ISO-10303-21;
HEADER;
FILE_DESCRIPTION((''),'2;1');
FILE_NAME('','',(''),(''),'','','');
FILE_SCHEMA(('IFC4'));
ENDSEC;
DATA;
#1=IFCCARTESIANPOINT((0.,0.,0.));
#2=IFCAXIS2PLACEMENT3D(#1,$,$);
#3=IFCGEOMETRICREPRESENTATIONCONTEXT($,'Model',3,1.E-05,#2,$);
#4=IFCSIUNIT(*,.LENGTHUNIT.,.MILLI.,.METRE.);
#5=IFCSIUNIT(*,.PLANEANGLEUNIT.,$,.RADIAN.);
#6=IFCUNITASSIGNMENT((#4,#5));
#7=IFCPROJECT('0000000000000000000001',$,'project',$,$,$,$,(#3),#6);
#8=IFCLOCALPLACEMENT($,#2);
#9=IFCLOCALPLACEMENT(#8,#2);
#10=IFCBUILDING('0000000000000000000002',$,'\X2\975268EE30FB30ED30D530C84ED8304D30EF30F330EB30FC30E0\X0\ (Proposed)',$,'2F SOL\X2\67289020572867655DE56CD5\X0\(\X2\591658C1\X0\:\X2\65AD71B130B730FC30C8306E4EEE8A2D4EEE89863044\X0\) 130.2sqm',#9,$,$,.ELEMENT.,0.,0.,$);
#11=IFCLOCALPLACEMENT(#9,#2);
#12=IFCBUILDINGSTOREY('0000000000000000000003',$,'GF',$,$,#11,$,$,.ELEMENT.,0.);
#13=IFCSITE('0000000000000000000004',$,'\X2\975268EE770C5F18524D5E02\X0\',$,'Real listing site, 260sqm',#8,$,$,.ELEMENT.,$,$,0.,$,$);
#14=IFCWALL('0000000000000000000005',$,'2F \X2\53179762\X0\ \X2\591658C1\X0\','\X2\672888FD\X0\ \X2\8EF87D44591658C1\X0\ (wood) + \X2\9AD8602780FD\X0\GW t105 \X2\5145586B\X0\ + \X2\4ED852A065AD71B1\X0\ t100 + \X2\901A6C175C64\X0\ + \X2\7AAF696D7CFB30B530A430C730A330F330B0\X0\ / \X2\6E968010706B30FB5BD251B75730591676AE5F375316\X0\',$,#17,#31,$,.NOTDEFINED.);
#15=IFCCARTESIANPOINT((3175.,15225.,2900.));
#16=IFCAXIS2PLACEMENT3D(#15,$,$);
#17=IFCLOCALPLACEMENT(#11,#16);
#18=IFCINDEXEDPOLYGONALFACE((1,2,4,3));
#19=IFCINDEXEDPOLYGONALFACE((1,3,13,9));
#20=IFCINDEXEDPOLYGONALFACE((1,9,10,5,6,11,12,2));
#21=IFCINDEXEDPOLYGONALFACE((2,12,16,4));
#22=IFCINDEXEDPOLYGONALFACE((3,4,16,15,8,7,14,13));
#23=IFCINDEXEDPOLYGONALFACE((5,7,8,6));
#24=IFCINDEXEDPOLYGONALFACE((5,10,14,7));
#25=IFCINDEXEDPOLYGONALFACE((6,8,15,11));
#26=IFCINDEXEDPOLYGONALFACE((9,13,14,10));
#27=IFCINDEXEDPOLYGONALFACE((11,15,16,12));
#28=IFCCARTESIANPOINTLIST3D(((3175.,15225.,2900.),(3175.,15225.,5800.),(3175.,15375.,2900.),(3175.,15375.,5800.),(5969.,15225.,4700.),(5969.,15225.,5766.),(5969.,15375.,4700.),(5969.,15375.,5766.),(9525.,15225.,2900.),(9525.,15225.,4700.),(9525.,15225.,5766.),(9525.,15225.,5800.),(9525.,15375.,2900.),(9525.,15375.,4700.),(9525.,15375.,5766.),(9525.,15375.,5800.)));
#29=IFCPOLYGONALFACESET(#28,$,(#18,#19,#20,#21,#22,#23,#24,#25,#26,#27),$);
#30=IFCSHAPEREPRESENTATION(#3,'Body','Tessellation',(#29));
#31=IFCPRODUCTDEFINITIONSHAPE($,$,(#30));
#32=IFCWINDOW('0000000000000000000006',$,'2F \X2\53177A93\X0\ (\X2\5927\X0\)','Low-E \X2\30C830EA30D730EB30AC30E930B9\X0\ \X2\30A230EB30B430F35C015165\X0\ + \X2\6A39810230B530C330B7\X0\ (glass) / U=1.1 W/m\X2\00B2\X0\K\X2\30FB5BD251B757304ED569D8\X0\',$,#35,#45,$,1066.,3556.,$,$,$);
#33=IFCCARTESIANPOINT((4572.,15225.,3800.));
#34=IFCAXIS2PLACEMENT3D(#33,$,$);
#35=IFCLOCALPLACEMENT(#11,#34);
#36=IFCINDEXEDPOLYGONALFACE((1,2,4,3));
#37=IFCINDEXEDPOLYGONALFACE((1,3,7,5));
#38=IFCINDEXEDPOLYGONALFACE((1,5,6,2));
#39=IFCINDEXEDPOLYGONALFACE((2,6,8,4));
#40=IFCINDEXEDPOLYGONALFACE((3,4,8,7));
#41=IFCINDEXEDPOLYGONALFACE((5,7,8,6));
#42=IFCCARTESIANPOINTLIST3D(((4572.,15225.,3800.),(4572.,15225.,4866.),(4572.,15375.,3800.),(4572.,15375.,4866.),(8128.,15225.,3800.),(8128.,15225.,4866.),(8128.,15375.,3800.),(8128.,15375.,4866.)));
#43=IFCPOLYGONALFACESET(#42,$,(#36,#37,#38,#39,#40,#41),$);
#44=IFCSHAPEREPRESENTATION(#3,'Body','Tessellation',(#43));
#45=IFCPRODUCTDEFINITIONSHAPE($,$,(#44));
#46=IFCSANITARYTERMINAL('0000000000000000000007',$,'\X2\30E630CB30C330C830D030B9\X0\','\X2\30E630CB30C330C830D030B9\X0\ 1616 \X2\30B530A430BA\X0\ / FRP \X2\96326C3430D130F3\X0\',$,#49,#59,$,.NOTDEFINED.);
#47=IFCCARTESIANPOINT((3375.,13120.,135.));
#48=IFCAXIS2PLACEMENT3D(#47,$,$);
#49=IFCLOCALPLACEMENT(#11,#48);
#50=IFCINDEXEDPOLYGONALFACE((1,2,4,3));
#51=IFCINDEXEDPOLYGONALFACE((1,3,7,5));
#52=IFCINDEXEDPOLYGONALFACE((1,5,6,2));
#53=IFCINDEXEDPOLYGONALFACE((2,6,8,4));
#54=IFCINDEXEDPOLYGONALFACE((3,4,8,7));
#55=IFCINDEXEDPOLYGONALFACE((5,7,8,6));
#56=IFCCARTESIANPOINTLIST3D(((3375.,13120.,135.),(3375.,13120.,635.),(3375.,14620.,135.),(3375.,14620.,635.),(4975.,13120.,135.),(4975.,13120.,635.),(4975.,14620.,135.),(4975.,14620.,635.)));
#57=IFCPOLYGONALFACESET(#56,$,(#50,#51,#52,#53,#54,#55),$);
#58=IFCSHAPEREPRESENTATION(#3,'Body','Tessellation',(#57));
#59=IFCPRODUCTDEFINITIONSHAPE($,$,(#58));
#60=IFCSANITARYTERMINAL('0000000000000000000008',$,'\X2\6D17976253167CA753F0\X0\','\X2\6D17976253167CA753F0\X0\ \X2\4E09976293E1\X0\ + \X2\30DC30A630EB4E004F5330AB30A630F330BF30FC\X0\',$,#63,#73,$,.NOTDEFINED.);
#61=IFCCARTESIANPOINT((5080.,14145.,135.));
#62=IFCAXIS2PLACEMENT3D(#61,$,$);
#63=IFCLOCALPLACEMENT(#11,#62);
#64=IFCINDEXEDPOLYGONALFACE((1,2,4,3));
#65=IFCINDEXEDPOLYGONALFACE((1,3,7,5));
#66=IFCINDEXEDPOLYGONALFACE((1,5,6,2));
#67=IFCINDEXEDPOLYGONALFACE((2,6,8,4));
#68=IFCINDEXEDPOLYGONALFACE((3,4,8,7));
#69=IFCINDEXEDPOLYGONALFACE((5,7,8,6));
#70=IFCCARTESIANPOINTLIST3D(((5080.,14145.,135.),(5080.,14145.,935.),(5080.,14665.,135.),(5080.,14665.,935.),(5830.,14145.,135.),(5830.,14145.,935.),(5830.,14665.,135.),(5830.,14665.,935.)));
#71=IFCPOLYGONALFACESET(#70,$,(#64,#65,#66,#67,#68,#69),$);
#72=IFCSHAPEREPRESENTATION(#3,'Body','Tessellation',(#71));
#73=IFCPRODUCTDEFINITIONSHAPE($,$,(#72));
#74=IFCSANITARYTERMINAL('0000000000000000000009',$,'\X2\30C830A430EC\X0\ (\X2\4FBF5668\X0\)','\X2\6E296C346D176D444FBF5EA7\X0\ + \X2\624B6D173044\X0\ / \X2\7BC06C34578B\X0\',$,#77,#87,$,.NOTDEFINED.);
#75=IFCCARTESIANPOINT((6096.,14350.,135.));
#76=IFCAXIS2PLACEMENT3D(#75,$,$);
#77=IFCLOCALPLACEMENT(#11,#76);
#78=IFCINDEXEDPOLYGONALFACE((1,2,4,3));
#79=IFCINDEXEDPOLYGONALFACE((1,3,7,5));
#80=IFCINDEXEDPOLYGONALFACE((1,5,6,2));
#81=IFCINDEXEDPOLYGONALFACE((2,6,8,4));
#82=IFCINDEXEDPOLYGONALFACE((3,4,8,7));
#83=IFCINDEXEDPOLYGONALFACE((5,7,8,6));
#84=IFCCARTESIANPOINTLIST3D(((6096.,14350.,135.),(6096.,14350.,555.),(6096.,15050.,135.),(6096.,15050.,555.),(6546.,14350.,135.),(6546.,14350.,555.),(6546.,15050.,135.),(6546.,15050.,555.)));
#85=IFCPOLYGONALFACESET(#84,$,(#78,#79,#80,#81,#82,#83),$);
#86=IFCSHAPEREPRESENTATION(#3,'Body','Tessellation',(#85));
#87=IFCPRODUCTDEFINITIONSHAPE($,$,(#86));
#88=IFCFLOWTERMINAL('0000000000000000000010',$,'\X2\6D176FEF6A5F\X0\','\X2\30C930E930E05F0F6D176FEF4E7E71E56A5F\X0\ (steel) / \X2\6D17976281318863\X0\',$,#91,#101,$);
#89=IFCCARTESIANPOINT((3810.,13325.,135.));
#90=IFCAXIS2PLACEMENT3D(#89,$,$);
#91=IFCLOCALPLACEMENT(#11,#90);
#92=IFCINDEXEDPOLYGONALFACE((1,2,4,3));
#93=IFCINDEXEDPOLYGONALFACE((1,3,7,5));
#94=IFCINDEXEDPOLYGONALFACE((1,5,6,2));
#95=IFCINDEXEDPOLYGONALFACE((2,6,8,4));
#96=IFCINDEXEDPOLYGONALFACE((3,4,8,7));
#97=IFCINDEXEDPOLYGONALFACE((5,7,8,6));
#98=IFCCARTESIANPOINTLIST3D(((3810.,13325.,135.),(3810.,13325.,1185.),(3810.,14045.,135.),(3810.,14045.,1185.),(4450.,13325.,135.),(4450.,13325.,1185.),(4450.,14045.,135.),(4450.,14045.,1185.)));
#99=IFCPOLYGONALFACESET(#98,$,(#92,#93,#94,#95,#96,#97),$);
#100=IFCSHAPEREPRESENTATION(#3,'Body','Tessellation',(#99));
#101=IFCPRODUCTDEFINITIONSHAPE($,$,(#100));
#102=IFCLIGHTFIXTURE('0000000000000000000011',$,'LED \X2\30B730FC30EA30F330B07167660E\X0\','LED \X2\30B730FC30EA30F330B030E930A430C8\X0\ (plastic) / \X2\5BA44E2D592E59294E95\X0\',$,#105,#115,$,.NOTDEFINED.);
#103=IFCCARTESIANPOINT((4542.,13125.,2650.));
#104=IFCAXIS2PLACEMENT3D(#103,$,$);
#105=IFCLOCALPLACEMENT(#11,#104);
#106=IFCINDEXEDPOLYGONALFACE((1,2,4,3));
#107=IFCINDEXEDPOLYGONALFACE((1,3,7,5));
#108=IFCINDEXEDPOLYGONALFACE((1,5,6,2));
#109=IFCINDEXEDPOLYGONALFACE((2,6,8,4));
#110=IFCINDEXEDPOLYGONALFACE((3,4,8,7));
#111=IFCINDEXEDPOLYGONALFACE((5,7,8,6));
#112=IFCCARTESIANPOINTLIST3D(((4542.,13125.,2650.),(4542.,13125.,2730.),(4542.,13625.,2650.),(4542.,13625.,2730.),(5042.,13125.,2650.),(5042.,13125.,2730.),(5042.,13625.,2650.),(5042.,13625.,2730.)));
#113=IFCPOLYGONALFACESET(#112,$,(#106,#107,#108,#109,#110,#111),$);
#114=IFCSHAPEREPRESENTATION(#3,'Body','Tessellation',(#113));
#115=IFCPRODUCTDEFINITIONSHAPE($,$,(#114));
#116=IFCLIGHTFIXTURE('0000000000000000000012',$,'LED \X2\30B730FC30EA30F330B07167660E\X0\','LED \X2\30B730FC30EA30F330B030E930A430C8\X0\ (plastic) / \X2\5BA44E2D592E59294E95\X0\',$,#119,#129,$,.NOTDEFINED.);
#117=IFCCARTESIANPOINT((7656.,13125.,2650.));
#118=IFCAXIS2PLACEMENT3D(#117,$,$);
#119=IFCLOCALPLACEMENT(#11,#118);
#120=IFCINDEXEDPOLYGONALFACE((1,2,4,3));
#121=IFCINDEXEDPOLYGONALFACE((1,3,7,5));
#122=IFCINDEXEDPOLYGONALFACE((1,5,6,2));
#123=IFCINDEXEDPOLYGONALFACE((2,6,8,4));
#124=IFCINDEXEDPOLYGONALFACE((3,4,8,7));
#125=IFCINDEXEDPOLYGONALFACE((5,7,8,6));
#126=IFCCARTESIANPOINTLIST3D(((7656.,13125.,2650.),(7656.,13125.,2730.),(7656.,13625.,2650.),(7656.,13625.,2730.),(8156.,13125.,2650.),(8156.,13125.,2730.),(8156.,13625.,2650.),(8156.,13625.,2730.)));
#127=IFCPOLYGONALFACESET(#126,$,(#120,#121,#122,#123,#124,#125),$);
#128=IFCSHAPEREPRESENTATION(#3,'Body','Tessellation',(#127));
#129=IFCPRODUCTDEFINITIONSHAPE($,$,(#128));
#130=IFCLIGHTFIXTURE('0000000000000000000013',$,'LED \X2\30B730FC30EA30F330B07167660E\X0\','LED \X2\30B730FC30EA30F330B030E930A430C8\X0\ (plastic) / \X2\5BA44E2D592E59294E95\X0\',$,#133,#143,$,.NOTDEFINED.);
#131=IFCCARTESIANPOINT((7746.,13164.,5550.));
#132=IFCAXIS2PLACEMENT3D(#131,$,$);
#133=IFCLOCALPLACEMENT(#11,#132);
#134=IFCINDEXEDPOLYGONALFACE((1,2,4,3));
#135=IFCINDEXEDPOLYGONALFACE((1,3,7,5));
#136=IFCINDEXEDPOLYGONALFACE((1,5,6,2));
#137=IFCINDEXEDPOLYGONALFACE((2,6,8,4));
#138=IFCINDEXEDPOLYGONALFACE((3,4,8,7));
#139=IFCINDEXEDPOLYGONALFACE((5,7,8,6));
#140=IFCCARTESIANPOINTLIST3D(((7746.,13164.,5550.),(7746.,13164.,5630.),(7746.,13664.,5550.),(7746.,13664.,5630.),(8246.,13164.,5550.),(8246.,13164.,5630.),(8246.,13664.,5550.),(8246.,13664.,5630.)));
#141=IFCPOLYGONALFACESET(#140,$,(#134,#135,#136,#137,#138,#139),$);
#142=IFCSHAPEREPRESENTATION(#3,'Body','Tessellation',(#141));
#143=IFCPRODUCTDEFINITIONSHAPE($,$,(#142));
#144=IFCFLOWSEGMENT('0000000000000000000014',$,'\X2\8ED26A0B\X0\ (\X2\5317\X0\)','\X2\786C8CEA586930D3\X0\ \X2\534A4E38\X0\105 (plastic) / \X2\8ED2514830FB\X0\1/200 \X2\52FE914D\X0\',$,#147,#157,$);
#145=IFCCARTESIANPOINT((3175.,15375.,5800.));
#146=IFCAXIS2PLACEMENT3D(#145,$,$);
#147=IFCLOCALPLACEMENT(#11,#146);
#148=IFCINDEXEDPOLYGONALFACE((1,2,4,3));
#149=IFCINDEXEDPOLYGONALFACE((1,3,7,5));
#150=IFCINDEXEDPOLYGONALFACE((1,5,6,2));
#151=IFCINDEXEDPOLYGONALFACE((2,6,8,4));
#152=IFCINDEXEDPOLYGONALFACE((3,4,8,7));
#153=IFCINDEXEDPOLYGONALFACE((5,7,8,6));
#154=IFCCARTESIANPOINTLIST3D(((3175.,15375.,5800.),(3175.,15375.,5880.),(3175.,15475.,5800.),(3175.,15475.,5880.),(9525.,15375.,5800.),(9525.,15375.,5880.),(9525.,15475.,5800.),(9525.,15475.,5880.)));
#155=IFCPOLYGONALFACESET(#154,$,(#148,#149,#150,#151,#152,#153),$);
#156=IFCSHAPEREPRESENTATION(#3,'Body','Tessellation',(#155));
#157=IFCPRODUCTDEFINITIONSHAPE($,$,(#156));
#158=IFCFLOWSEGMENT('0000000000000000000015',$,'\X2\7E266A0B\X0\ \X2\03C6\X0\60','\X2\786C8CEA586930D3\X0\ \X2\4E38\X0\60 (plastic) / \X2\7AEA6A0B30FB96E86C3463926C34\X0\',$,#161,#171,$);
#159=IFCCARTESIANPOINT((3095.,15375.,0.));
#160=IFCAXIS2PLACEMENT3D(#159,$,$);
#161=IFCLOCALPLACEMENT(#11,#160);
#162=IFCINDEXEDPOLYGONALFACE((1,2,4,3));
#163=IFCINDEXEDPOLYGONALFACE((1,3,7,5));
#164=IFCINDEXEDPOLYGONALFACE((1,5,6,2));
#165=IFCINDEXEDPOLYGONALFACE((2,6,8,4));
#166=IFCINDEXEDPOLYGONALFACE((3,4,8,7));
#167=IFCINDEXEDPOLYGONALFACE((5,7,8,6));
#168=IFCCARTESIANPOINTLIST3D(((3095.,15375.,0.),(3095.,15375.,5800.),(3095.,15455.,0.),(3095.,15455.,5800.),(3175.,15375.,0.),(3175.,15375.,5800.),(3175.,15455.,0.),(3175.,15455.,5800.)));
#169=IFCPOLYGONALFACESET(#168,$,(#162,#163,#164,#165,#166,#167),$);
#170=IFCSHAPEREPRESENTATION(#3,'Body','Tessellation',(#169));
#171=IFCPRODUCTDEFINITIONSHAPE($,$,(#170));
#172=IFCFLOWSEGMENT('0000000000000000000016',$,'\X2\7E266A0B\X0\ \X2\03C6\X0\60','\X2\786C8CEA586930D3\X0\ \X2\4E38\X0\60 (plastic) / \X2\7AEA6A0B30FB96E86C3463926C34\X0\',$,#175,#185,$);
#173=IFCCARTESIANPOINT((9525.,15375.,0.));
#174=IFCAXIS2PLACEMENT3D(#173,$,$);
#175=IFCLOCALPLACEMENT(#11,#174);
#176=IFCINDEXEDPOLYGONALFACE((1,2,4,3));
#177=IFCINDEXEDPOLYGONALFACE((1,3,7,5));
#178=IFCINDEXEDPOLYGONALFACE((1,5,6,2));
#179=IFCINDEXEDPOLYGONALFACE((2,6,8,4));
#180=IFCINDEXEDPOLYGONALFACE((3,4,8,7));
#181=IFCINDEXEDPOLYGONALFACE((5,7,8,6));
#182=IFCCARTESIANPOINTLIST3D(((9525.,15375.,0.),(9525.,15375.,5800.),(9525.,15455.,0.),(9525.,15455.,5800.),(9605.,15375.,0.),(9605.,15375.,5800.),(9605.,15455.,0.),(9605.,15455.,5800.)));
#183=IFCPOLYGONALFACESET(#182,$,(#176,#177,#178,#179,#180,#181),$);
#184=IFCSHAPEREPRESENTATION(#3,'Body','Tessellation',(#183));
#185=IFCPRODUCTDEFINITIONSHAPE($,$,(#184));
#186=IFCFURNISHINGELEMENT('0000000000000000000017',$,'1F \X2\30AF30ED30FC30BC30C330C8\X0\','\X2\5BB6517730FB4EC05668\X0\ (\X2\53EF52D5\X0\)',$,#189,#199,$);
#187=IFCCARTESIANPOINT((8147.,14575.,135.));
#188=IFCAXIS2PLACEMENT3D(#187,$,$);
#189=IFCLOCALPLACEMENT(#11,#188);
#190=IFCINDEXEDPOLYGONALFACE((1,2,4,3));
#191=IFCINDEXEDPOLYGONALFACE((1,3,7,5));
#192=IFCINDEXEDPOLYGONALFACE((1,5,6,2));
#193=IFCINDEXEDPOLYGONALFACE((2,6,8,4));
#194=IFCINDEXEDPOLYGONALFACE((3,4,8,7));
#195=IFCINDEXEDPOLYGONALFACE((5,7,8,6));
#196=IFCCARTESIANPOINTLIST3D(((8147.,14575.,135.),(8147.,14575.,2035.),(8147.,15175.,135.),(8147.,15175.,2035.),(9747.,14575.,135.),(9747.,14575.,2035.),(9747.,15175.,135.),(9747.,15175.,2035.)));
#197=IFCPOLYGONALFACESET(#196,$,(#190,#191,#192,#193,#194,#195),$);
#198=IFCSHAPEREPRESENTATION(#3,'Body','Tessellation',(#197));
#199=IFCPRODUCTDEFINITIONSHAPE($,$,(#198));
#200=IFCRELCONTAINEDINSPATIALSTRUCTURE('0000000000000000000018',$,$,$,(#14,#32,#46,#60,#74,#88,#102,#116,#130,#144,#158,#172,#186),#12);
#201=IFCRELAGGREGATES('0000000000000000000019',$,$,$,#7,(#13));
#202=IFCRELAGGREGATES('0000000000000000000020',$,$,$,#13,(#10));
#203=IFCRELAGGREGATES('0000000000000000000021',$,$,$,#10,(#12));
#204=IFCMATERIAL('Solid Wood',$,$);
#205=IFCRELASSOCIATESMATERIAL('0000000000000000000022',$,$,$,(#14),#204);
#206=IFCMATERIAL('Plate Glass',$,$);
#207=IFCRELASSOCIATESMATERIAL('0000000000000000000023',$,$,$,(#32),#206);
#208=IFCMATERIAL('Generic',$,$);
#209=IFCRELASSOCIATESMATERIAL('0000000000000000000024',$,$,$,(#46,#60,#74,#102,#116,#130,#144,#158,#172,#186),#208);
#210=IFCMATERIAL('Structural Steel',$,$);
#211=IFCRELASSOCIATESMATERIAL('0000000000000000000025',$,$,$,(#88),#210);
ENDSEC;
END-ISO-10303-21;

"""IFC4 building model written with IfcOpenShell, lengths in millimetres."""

from ifc_helpers import new_model, si_unit, frame, frame_2d, origin, place, context, project, spatial, rectangle, extrude, material, element, fill, save


model = new_model("IFC4")

# Units and contexts
model_context = context("Model", 3, precision=1e-05, world=origin())
ifc_project = project(units=[si_unit("LENGTHUNIT", "METRE", prefix="MILLI"), si_unit("PLANEANGLEUNIT", "RADIAN")], contexts=[model_context])

# Site, building, storey
site_placement = place(None, origin())
site = spatial("IfcSite", under=ifc_project, at=site_placement, Name="青森県弘前市", ObjectType="Real listing site, 260sqm", CompositionType="ELEMENT", RefElevation=0.0)
building_placement = place(site_placement, origin())
building = spatial("IfcBuilding", under=site, at=building_placement, Name="青森・ロフト付きワンルーム (Proposed)", ObjectType="2F SOL木造在来工法(外壁:断熱シートの仮設仮覆い) 130.2sqm", CompositionType="ELEMENT", ElevationOfRefHeight=0.0, ElevationOfTerrain=0.0)
storey_placement = place(building_placement, origin())
storey = spatial("IfcBuildingStorey", under=building, at=storey_placement, Name="GF", CompositionType="ELEMENT", Elevation=0.0)

# Shared definitions
ifc_material_1 = material(Name="Solid Wood")

# Shared definitions
ifc_material_2 = material(Name="Plate Glass")

# Wall, opening, window
wall_1_placement = place(storey_placement, frame((3175.0, 15225.0, 2900.0)))
wall_1 = element("IfcWall", 1, at=wall_1_placement, inside=storey, material=ifc_material_1, Name="2F 北面 外壁", Description="木製 軸組外壁 (wood) + 高性能GW t105 充填 + 付加断熱 t100 + 通気層 + 窯業系サイディング / 準耐火・寒冷地外皮強化", PredefinedType="NOTDEFINED", context=model_context, shape_type="SweptSolid", body=[
    extrude(rectangle(XDim=6350.0, YDim=150.0, at=frame_2d((3175.0, 75.0))), frame((3175.0, 15225.0, 2900.0)), (0.0, 0.0, 1.0), 2900.0),
])
opening_1_placement = place(storey_placement, frame((4572.0, 15225.0, 3800.0)))
opening_1 = element("IfcOpeningElement", 2, at=opening_1_placement, cuts=wall_1, PredefinedType="NOTDEFINED", context=model_context, shape_type="SweptSolid", body=[
    extrude(rectangle(XDim=3556.0, YDim=150.0, at=frame_2d((1778.0, 75.0))), frame((4572.0, 15225.0, 3800.0)), (0.0, 0.0, 1.0), 1066.0),
])
window_1_placement = place(storey_placement, frame((4572.0, 15225.0, 3800.0)))
window_1 = element("IfcWindow", 3, at=window_1_placement, inside=storey, material=ifc_material_2, Name="2F 北窓 (大)", Description="Low-E トリプルガラス アルゴン封入 + 樹脂サッシ (glass) / U=1.1 W/m²K・寒冷地仕様", OverallHeight=1066.0, OverallWidth=3556.0, context=model_context, shape_type="SweptSolid", body=[
    extrude(rectangle(XDim=3556.0, YDim=150.0, at=frame_2d((1778.0, 75.0))), frame((4572.0, 15225.0, 3800.0)), (0.0, 0.0, 1.0), 1066.0),
])
fill(opening_1, window_1)

# Sanitary terminals
ifc_material_3 = material(Name="Generic")
sanitary_terminal_1_placement = place(storey_placement, frame((3375.0, 13120.0, 135.0)))
element("IfcSanitaryTerminal", 4, at=sanitary_terminal_1_placement, inside=storey, material=ifc_material_3, Name="ユニットバス", Description="ユニットバス 1616 サイズ / FRP 防水パン", PredefinedType="NOTDEFINED", context=model_context, shape_type="SweptSolid", body=[
    extrude(rectangle(XDim=1600.0, YDim=1500.0, at=frame_2d((800.0, 750.0))), frame((3375.0, 13120.0, 135.0)), (0.0, 0.0, 1.0), 500.0),
])
sanitary_terminal_2_placement = place(storey_placement, frame((5080.0, 14145.0, 135.0)))
element("IfcSanitaryTerminal", 5, at=sanitary_terminal_2_placement, inside=storey, material=ifc_material_3, Name="洗面化粧台", Description="洗面化粧台 三面鏡 + ボウル一体カウンター", PredefinedType="NOTDEFINED", context=model_context, shape_type="SweptSolid", body=[
    extrude(rectangle(XDim=750.0, YDim=520.0, at=frame_2d((375.0, 260.0))), frame((5080.0, 14145.0, 135.0)), (0.0, 0.0, 1.0), 800.0),
])
sanitary_terminal_3_placement = place(storey_placement, frame((6096.0, 14350.0, 135.0)))
element("IfcSanitaryTerminal", 6, at=sanitary_terminal_3_placement, inside=storey, material=ifc_material_3, Name="トイレ (便器)", Description="温水洗浄便座 + 手洗い / 節水型", PredefinedType="NOTDEFINED", context=model_context, shape_type="SweptSolid", body=[
    extrude(rectangle(XDim=450.0, YDim=700.0, at=frame_2d((225.0, 350.0))), frame((6096.0, 14350.0, 135.0)), (0.0, 0.0, 1.0), 420.0),
])

# Flow terminal
ifc_material_4 = material(Name="Structural Steel")
flow_terminal_placement = place(storey_placement, frame((3810.0, 13325.0, 135.0)))
element("IfcFlowTerminal", 7, at=flow_terminal_placement, inside=storey, material=ifc_material_4, Name="洗濯機", Description="ドラム式洗濯乾燥機 (steel) / 洗面脱衣", context=model_context, shape_type="SweptSolid", body=[
    extrude(rectangle(XDim=640.0, YDim=720.0, at=frame_2d((320.0, 360.0))), frame((3810.0, 13325.0, 135.0)), (0.0, 0.0, 1.0), 1050.0),
])

# Light fixtures
light_fixture_1_placement = place(storey_placement, frame((4542.0, 13125.0, 2650.0)))
element("IfcLightFixture", 8, at=light_fixture_1_placement, inside=storey, material=ifc_material_3, Name="LED シーリング照明", Description="LED シーリングライト (plastic) / 室中央天井", PredefinedType="NOTDEFINED", context=model_context, shape_type="SweptSolid", body=[
    extrude(rectangle(XDim=500.0, YDim=500.0, at=frame_2d((250.0, 250.0))), frame((4542.0, 13125.0, 2650.0)), (0.0, 0.0, 1.0), 80.0),
])
light_fixture_2_placement = place(storey_placement, frame((7656.0, 13125.0, 2650.0)))
element("IfcLightFixture", 9, at=light_fixture_2_placement, inside=storey, material=ifc_material_3, Name="LED シーリング照明", Description="LED シーリングライト (plastic) / 室中央天井", PredefinedType="NOTDEFINED", context=model_context, shape_type="SweptSolid", body=[
    extrude(rectangle(XDim=500.0, YDim=500.0, at=frame_2d((250.0, 250.0))), frame((7656.0, 13125.0, 2650.0)), (0.0, 0.0, 1.0), 80.0),
])
light_fixture_3_placement = place(storey_placement, frame((7746.0, 13164.0, 5550.0)))
element("IfcLightFixture", 10, at=light_fixture_3_placement, inside=storey, material=ifc_material_3, Name="LED シーリング照明", Description="LED シーリングライト (plastic) / 室中央天井", PredefinedType="NOTDEFINED", context=model_context, shape_type="SweptSolid", body=[
    extrude(rectangle(XDim=500.0, YDim=500.0, at=frame_2d((250.0, 250.0))), frame((7746.0, 13164.0, 5550.0)), (0.0, 0.0, 1.0), 80.0),
])

# Flow segments
flow_segment_1_placement = place(storey_placement, frame((3175.0, 15375.0, 5800.0)))
element("IfcFlowSegment", 11, at=flow_segment_1_placement, inside=storey, material=ifc_material_3, Name="軒樋 (北)", Description="硬質塩ビ 半丸105 (plastic) / 軒先・1/200 勾配", context=model_context, shape_type="SweptSolid", body=[
    extrude(rectangle(XDim=6350.0, YDim=100.0, at=frame_2d((3175.0, 50.0))), frame((3175.0, 15375.0, 5800.0)), (0.0, 0.0, 1.0), 80.0),
])
flow_segment_2_placement = place(storey_placement, frame((3095.0, 15375.0, 0.0)))
element("IfcFlowSegment", 12, at=flow_segment_2_placement, inside=storey, material=ifc_material_3, Name="縦樋 φ60", Description="硬質塩ビ 丸60 (plastic) / 竪樋・雨水排水", context=model_context, shape_type="SweptSolid", body=[
    extrude(rectangle(XDim=80.0, YDim=80.0, at=frame_2d((40.0, 40.0))), frame((3095.0, 15375.0, 0.0)), (0.0, 0.0, 1.0), 5800.0),
])
flow_segment_3_placement = place(storey_placement, frame((9525.0, 15375.0, 0.0)))
element("IfcFlowSegment", 13, at=flow_segment_3_placement, inside=storey, material=ifc_material_3, Name="縦樋 φ60", Description="硬質塩ビ 丸60 (plastic) / 竪樋・雨水排水", context=model_context, shape_type="SweptSolid", body=[
    extrude(rectangle(XDim=80.0, YDim=80.0, at=frame_2d((40.0, 40.0))), frame((9525.0, 15375.0, 0.0)), (0.0, 0.0, 1.0), 5800.0),
])

# Furnishing element
furnishing_1_placement = place(storey_placement, frame((8147.0, 14575.0, 135.0)))
element("IfcFurnishingElement", 14, at=furnishing_1_placement, inside=storey, material=ifc_material_3, Name="1F クローゼット", Description="家具・什器 (可動)", context=model_context, shape_type="SweptSolid", body=[
    extrude(rectangle(XDim=1600.0, YDim=600.0, at=frame_2d((800.0, 300.0))), frame((8147.0, 14575.0, 135.0)), (0.0, 0.0, 1.0), 1900.0),
])

save(model, "model.ifc")
